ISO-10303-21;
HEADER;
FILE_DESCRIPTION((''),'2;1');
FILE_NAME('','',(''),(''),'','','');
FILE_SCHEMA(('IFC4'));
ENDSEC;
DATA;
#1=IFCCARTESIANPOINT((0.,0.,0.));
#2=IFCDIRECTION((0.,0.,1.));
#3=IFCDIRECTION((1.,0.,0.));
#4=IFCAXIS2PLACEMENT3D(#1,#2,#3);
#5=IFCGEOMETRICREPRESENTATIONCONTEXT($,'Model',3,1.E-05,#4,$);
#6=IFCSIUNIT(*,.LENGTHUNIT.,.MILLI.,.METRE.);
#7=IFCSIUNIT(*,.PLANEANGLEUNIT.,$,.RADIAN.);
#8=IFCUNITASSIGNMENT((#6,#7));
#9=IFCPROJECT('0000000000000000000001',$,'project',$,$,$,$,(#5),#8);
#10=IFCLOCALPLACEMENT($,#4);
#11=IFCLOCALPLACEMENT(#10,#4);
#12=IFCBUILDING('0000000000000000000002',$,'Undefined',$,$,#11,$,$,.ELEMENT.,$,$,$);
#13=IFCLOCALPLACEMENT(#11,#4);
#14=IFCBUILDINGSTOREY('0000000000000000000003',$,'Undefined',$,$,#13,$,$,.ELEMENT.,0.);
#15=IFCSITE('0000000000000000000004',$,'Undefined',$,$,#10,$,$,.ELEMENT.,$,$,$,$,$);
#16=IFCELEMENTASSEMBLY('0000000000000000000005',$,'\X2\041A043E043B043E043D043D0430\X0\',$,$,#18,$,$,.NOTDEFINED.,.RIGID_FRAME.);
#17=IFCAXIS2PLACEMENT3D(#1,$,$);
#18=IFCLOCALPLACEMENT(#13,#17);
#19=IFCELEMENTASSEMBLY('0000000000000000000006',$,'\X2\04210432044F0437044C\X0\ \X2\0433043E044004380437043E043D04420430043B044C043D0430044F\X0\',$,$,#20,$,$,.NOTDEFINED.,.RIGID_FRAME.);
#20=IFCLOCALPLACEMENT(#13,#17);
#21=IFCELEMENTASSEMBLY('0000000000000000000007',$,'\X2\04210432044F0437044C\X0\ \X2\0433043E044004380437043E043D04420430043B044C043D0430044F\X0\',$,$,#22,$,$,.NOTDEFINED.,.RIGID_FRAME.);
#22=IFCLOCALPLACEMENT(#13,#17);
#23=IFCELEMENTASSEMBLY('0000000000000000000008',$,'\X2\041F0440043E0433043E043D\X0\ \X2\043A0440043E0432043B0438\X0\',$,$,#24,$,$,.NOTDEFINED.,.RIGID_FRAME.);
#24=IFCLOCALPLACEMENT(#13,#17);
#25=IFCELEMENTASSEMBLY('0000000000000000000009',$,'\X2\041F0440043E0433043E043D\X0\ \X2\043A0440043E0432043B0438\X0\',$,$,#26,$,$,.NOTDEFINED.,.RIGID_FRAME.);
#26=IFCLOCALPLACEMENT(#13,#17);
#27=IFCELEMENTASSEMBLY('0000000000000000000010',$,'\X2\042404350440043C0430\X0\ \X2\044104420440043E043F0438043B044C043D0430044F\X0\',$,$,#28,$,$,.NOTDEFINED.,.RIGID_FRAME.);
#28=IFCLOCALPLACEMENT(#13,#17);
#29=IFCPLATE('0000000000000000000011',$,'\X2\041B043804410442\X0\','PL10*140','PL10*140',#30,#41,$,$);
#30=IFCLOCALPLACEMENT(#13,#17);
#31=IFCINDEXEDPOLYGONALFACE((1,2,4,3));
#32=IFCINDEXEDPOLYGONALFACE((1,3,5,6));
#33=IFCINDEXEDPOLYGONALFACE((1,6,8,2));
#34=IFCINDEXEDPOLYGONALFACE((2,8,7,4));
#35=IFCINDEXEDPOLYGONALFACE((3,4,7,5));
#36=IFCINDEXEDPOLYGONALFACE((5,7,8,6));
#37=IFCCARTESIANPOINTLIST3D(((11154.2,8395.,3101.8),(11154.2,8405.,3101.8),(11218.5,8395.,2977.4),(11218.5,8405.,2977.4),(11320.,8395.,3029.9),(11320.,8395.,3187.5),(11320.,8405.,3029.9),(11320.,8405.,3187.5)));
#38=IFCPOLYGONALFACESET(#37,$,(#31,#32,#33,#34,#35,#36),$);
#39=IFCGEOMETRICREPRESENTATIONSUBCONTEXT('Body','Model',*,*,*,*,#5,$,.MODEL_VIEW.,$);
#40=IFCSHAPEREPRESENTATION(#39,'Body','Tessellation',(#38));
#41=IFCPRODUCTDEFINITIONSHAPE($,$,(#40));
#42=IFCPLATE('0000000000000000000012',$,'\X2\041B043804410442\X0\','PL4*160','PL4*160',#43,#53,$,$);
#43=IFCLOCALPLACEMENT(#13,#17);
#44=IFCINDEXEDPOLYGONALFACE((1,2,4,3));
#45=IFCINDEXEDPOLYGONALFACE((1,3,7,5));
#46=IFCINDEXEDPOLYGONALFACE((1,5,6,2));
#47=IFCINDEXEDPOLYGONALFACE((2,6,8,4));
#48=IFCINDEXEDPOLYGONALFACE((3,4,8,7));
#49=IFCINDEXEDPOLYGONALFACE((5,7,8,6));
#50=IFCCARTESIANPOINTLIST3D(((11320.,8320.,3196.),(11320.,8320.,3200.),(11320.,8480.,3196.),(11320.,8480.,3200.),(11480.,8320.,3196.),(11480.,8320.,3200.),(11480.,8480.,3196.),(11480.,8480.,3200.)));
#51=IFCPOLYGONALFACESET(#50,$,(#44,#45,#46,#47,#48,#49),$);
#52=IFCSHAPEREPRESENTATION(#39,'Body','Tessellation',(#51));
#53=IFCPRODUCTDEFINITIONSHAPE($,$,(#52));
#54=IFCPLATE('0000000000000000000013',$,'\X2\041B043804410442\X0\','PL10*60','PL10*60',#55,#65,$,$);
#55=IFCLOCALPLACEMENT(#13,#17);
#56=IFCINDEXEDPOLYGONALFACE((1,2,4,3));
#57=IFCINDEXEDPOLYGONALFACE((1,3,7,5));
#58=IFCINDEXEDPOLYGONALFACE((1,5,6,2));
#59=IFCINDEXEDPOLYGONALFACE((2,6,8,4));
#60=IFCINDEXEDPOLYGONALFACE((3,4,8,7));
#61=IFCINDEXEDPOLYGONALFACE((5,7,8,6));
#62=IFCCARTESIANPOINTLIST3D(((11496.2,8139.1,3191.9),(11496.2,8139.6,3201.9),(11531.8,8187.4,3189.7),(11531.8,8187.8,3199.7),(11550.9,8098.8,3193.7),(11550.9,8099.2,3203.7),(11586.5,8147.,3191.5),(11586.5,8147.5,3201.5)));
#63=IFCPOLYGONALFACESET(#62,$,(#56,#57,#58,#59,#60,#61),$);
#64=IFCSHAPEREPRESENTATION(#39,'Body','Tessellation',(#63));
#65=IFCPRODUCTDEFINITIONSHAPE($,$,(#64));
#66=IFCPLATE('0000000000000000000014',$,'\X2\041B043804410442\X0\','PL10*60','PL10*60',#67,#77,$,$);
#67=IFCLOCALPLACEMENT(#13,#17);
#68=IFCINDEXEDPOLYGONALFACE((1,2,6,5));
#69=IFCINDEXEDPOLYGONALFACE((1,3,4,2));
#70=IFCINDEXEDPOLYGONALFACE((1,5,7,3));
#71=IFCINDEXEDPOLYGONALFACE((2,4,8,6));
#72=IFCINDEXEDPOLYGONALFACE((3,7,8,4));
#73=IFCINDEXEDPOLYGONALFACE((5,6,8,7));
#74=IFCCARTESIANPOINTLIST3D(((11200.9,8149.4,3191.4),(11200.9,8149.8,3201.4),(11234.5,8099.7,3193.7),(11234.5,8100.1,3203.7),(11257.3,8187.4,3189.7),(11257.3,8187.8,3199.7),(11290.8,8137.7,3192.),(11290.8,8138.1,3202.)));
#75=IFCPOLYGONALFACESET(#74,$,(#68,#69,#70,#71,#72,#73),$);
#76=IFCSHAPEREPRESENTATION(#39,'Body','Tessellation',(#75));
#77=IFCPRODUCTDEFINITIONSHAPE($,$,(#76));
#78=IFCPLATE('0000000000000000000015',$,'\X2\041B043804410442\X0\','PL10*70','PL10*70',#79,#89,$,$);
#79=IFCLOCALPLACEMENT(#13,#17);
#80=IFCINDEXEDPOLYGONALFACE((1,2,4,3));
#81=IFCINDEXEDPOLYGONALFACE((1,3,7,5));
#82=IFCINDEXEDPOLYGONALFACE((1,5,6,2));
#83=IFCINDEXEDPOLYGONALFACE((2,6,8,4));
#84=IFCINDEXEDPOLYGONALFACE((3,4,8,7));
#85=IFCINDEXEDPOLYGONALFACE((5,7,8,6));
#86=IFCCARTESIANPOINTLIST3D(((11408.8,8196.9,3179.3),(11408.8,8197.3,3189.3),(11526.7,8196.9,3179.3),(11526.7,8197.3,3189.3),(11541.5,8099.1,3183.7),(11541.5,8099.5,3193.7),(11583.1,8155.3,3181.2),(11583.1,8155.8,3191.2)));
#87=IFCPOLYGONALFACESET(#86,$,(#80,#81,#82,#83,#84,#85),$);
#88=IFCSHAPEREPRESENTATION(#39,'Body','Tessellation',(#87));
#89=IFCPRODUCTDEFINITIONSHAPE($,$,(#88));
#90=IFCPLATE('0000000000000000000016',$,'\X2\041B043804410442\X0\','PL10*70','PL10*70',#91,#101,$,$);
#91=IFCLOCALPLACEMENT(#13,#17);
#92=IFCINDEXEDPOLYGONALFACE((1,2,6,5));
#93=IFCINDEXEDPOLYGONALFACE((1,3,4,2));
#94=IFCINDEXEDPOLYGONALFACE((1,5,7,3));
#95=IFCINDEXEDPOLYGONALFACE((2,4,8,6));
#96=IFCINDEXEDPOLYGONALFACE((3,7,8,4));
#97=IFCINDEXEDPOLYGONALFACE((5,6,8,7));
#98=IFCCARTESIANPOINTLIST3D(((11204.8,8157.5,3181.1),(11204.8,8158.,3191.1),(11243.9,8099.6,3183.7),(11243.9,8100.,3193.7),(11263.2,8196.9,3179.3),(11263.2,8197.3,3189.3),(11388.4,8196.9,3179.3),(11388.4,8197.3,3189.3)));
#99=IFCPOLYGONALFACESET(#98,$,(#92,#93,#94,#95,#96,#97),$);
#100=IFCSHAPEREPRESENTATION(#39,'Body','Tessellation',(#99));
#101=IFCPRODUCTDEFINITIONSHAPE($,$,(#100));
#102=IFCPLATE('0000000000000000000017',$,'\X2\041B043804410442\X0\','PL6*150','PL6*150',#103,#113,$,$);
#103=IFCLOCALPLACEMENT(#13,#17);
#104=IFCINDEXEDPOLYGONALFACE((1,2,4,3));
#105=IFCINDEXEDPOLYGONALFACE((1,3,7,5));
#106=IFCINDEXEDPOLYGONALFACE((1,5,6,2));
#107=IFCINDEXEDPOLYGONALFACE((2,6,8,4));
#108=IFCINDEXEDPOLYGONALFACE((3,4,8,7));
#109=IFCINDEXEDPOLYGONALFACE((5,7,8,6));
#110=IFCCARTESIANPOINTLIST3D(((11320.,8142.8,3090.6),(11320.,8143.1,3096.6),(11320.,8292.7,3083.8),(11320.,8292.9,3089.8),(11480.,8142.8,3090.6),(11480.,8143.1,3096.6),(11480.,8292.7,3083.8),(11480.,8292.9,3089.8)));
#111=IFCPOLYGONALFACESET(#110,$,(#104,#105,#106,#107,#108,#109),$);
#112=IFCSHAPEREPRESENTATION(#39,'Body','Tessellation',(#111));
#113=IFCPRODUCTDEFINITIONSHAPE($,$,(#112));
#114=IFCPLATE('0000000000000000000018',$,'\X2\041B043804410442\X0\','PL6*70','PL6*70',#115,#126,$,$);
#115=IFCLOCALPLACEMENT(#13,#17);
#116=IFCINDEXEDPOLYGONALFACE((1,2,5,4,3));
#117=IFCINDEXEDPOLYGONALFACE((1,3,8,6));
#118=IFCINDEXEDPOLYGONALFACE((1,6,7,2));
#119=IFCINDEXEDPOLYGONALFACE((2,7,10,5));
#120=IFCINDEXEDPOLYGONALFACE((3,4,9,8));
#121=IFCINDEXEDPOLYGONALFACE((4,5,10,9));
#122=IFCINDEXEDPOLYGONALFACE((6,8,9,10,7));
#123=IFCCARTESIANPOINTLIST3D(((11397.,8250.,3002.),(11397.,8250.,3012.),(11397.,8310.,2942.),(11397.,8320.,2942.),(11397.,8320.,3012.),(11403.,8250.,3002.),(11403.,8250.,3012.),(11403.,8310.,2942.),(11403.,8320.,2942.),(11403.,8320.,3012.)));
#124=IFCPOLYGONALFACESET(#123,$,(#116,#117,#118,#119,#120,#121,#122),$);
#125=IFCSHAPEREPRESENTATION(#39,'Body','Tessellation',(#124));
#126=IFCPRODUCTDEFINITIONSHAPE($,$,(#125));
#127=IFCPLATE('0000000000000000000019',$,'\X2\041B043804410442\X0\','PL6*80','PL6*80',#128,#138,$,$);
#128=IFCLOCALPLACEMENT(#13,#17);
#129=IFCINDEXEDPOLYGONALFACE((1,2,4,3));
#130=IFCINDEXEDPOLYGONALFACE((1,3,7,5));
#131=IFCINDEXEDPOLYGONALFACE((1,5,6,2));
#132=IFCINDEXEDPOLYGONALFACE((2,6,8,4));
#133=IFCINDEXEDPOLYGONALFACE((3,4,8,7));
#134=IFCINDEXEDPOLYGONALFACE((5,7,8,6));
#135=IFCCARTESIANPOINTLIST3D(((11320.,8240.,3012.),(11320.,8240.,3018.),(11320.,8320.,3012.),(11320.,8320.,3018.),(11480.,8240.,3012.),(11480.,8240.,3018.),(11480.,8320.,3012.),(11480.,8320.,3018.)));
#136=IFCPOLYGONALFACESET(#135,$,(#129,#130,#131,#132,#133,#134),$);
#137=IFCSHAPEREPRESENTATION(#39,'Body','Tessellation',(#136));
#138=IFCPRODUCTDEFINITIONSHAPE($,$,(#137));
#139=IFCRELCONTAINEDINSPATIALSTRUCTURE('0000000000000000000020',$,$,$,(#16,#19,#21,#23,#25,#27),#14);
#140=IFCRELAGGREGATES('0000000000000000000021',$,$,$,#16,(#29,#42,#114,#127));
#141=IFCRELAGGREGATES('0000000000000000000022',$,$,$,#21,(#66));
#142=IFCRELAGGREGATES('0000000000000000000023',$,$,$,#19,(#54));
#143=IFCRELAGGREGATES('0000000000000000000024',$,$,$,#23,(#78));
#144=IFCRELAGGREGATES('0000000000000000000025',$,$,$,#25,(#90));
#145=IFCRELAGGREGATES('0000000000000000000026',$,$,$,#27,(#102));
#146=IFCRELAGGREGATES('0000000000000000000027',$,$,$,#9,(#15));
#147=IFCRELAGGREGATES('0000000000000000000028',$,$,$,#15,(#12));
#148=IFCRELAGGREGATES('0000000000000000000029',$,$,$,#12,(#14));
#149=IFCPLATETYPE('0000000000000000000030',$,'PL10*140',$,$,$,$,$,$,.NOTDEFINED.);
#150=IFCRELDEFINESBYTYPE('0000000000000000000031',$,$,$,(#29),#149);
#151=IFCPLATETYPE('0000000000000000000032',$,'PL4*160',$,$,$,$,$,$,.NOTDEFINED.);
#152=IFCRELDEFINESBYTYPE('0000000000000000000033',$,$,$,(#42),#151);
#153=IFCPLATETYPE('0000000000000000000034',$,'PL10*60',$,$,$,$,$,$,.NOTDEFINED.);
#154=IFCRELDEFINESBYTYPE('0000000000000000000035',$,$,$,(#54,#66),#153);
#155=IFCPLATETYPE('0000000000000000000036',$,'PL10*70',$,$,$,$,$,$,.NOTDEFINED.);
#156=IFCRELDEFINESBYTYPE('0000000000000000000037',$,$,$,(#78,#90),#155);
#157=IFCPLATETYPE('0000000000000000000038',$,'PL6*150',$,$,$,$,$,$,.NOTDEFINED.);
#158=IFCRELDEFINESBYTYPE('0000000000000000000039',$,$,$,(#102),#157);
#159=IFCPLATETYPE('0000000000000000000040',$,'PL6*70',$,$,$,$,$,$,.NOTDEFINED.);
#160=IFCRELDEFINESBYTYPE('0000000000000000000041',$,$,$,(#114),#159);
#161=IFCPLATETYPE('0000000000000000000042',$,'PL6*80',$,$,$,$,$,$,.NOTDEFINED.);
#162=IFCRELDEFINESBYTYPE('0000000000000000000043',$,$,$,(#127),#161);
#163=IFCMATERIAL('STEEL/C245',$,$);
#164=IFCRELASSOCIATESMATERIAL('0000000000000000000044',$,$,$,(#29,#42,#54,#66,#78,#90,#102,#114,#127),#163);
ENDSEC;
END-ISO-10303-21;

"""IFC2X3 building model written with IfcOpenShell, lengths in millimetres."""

from ifc_helpers import new_model, si_unit, frame, origin_with_axes, place, context, subcontext, project, spatial, polyline, outline, extrude, material, type_object, element, aggregate, save


model = new_model("IFC2X3")

# Units and contexts
model_context = context("Model", 3, precision=1e-05, world=origin_with_axes())
body_context = subcontext(model_context, "Body", "Model", "MODEL_VIEW")
ifc_project = project(units=[si_unit("LENGTHUNIT", "METRE", prefix="MILLI"), si_unit("PLANEANGLEUNIT", "RADIAN")], contexts=[model_context])

# Site, building, storey
site_placement = place(None, origin_with_axes())
site = spatial("IfcSite", under=ifc_project, at=site_placement, Name="Undefined", CompositionType="ELEMENT")
building_placement = place(site_placement, origin_with_axes())
building = spatial("IfcBuilding", under=site, at=building_placement, Name="Undefined", CompositionType="ELEMENT")
storey_placement = place(building_placement, origin_with_axes())
storey = spatial("IfcBuildingStorey", under=building, at=storey_placement, Name="Undefined", CompositionType="ELEMENT", Elevation=0.0)

# Element assembly
ifc_material_1 = material(Name="STEEL/C245")
assembly_1_placement = place(storey_placement, origin_with_axes())
assembly_1 = element("IfcElementAssembly", 1, at=assembly_1_placement, inside=storey, Name="Колонна", AssemblyPlace="NOTDEFINED", PredefinedType="RIGID_FRAME")

# Element assemblies
assembly_2_placement = place(storey_placement, origin_with_axes())
assembly_2 = element("IfcElementAssembly", 2, at=assembly_2_placement, inside=storey, Name="Связь горизонтальная", AssemblyPlace="NOTDEFINED", PredefinedType="RIGID_FRAME")
assembly_3_placement = place(storey_placement, origin_with_axes())
assembly_3 = element("IfcElementAssembly", 3, at=assembly_3_placement, inside=storey, Name="Связь горизонтальная", AssemblyPlace="NOTDEFINED", PredefinedType="RIGID_FRAME")

# Element assemblies
assembly_4_placement = place(storey_placement, origin_with_axes())
assembly_4 = element("IfcElementAssembly", 4, at=assembly_4_placement, inside=storey, Name="Прогон кровли", AssemblyPlace="NOTDEFINED", PredefinedType="RIGID_FRAME")
assembly_5_placement = place(storey_placement, origin_with_axes())
assembly_5 = element("IfcElementAssembly", 5, at=assembly_5_placement, inside=storey, Name="Прогон кровли", AssemblyPlace="NOTDEFINED", PredefinedType="RIGID_FRAME")

# Element assembly
assembly_6_placement = place(storey_placement, origin_with_axes())
assembly_6 = element("IfcElementAssembly", 6, at=assembly_6_placement, inside=storey, Name="Ферма стропильная", AssemblyPlace="NOTDEFINED", PredefinedType="RIGID_FRAME")

# Plates
plate_type_1 = type_object("IfcPlateType", Name="PL10*140", PredefinedType="NOTDEFINED")
plate_1_placement = place(assembly_1_placement, frame((11320.0, 8400.0, 3187.5), z_axis=(0.0, -1.0, 0.0), x_axis=(-0.888426, 0.0, -0.45902)))
plate_1 = element("IfcPlate", 7, at=plate_1_placement, type_object=plate_type_1, material=ifc_material_1, Name="Лист", Description="PL10*140", ObjectType="PL10*140", context=body_context, shape_type="SweptSolid", body=[
    extrude(outline(polyline([(0.0, 0.0), (186.6, 0.0), (186.6, 140.0), (72.3, 140.0), (0.0, 0.0)])), frame((0.0, 0.0, -5.0), z_axis=(0.0, 0.0, 1.0), x_axis=(1.0, 0.0, 0.0)), (0.0, 0.0, 1.0), 10.0),
])
plate_type_2 = type_object("IfcPlateType", Name="PL4*160", PredefinedType="NOTDEFINED")
plate_2_placement = place(assembly_1_placement, frame((11400.0, 8320.0, 3198.0), z_axis=(0.0, 0.0, -1.0), x_axis=(0.0, 1.0, 0.0)))
plate_2 = element("IfcPlate", 8, at=plate_2_placement, type_object=plate_type_2, material=ifc_material_1, Name="Лист", Description="PL4*160", ObjectType="PL4*160", context=body_context, shape_type="SweptSolid", body=[
    extrude(outline(polyline([(0.0, -80.0), (0.0, 80.0), (160.0, 80.0), (160.0, -80.0), (0.0, -80.0)])), frame((0.0, 0.0, -2.0), z_axis=(0.0, 0.0, 1.0), x_axis=(1.0, 0.0, 0.0)), (0.0, 0.0, 1.0), 4.0),
])
plate_type_3 = type_object("IfcPlateType", Name="PL10*60", PredefinedType="NOTDEFINED")
plate_3_placement = place(assembly_2_placement, frame((11514.0, 8163.5, 3195.8), z_axis=(0.0, 0.045408, 0.998969), x_axis=(0.804616, -0.593183, 0.026963)))
plate_3 = element("IfcPlate", 9, at=plate_3_placement, type_object=plate_type_3, material=ifc_material_1, Name="Лист", Description="PL10*60", ObjectType="PL10*60", context=body_context, shape_type="SweptSolid", body=[
    extrude(outline(polyline([(0.0, -30.0), (0.0, 30.0), (68.0, 30.0), (68.0, -30.0), (0.0, -30.0)])), frame((0.0, 0.0, -5.0), z_axis=(0.0, 0.0, 1.0), x_axis=(1.0, 0.0, 0.0)), (0.0, 0.0, 1.0), 10.0),
])
plate_4_placement = place(assembly_3_placement, frame((11274.1, 8162.7, 3195.8), z_axis=(0.0, -0.045408, -0.998969), x_axis=(-0.829223, -0.558342, 0.025379)))
plate_4 = element("IfcPlate", 10, at=plate_4_placement, type_object=plate_type_3, material=ifc_material_1, Name="Лист", Description="PL10*60", ObjectType="PL10*60", context=body_context, shape_type="SweptSolid", body=[
    extrude(outline(polyline([(68.0, 30.0), (68.0, -30.0), (0.0, -30.0), (0.0, 30.0), (68.0, 30.0)])), frame((0.0, 0.0, -5.0), z_axis=(0.0, 0.0, 1.0), x_axis=(1.0, 0.0, 0.0)), (0.0, 0.0, 1.0), 10.0),
])
plate_type_4 = type_object("IfcPlateType", Name="PL10*70", PredefinedType="NOTDEFINED")
plate_5_placement = place(assembly_4_placement, frame((11408.8, 8197.1, 3184.3), z_axis=(0.0, 0.045408, 0.998969), x_axis=(0.804616, -0.593183, 0.026963)))
plate_5 = element("IfcPlate", 11, at=plate_5_placement, type_object=plate_type_4, material=ifc_material_1, Name="Лист", Description="PL10*70", ObjectType="PL10*70", context=body_context, shape_type="SweptSolid", body=[
    extrude(outline(polyline([(0.0, 0.0), (164.9, 0.0), (164.9, 70.0), (94.9, 70.0), (0.0, 0.0)])), frame((0.0, 0.0, -5.0), z_axis=(0.0, 0.0, 1.0), x_axis=(1.0, 0.0, 0.0)), (0.0, 0.0, 1.0), 10.0),
])
plate_6_placement = place(assembly_5_placement, frame((11388.4, 8197.1, 3184.3), z_axis=(0.0, -0.045408, -0.998969), x_axis=(-0.829223, -0.558342, 0.025379)))
plate_6 = element("IfcPlate", 12, at=plate_6_placement, type_object=plate_type_4, material=ifc_material_1, Name="Лист", Description="PL10*70", ObjectType="PL10*70", context=body_context, shape_type="SweptSolid", body=[
    extrude(outline(polyline([(0.0, 0.0), (174.3, 0.0), (174.3, 70.0), (103.9, 70.0), (0.0, 0.0)])), frame((0.0, 0.0, -5.0), z_axis=(0.0, 0.0, 1.0), x_axis=(1.0, 0.0, 0.0)), (0.0, 0.0, 1.0), 10.0),
])
plate_type_5 = type_object("IfcPlateType", Name="PL6*150", PredefinedType="NOTDEFINED")
plate_7_placement = place(assembly_6_placement, frame((11480.0, 8142.9, 3093.6), z_axis=(0.0, -0.045408, -0.998969), x_axis=(-1.0, 0.0, 0.0)))
plate_7 = element("IfcPlate", 13, at=plate_7_placement, type_object=plate_type_5, material=ifc_material_1, Name="Лист", Description="PL6*150", ObjectType="PL6*150", context=body_context, shape_type="SweptSolid", body=[
    extrude(outline(polyline([(0.0, 0.0), (160.0, 0.0), (160.0, 150.0), (0.0, 150.0), (0.0, 0.0)])), frame((0.0, 0.0, -3.0), z_axis=(0.0, 0.0, 1.0), x_axis=(1.0, 0.0, 0.0)), (0.0, 0.0, 1.0), 6.0),
])
plate_type_6 = type_object("IfcPlateType", Name="PL6*70", PredefinedType="NOTDEFINED")
plate_8_placement = place(assembly_1_placement, frame((11400.0, 8250.0, 3012.0), z_axis=(-1.0, 0.0, 0.0), x_axis=(0.0, 1.0, 0.0)))
plate_8 = element("IfcPlate", 14, at=plate_8_placement, type_object=plate_type_6, material=ifc_material_1, Name="Лист", Description="PL6*70", ObjectType="PL6*70", context=body_context, shape_type="SweptSolid", body=[
    extrude(outline(polyline([(0.0, 0.0), (70.0, 0.0), (70.0, 70.0), (60.0, 70.0), (0.0, 10.0), (0.0, 0.0)])), frame((0.0, 0.0, -3.0), z_axis=(0.0, 0.0, 1.0), x_axis=(1.0, 0.0, 0.0)), (0.0, 0.0, 1.0), 6.0),
])
plate_type_7 = type_object("IfcPlateType", Name="PL6*80", PredefinedType="NOTDEFINED")
plate_9_placement = place(assembly_1_placement, frame((11480.0, 8320.0, 3015.0), z_axis=(0.0, 0.0, 1.0), x_axis=(-1.0, 0.0, 0.0)))
plate_9 = element("IfcPlate", 15, at=plate_9_placement, type_object=plate_type_7, material=ifc_material_1, Name="Лист", Description="PL6*80", ObjectType="PL6*80", context=body_context, shape_type="SweptSolid", body=[
    extrude(outline(polyline([(0.0, 0.0), (160.0, 0.0), (160.0, 80.0), (0.0, 80.0), (0.0, 0.0)])), frame((0.0, 0.0, -3.0), z_axis=(0.0, 0.0, 1.0), x_axis=(1.0, 0.0, 0.0)), (0.0, 0.0, 1.0), 6.0),
])
aggregate(assembly_1, [plate_1, plate_2, plate_8, plate_9])

aggregate(assembly_3, [plate_4])
aggregate(assembly_2, [plate_3])
aggregate(assembly_4, [plate_5])
aggregate(assembly_5, [plate_6])
aggregate(assembly_6, [plate_7])

save(model, "model.ifc")
